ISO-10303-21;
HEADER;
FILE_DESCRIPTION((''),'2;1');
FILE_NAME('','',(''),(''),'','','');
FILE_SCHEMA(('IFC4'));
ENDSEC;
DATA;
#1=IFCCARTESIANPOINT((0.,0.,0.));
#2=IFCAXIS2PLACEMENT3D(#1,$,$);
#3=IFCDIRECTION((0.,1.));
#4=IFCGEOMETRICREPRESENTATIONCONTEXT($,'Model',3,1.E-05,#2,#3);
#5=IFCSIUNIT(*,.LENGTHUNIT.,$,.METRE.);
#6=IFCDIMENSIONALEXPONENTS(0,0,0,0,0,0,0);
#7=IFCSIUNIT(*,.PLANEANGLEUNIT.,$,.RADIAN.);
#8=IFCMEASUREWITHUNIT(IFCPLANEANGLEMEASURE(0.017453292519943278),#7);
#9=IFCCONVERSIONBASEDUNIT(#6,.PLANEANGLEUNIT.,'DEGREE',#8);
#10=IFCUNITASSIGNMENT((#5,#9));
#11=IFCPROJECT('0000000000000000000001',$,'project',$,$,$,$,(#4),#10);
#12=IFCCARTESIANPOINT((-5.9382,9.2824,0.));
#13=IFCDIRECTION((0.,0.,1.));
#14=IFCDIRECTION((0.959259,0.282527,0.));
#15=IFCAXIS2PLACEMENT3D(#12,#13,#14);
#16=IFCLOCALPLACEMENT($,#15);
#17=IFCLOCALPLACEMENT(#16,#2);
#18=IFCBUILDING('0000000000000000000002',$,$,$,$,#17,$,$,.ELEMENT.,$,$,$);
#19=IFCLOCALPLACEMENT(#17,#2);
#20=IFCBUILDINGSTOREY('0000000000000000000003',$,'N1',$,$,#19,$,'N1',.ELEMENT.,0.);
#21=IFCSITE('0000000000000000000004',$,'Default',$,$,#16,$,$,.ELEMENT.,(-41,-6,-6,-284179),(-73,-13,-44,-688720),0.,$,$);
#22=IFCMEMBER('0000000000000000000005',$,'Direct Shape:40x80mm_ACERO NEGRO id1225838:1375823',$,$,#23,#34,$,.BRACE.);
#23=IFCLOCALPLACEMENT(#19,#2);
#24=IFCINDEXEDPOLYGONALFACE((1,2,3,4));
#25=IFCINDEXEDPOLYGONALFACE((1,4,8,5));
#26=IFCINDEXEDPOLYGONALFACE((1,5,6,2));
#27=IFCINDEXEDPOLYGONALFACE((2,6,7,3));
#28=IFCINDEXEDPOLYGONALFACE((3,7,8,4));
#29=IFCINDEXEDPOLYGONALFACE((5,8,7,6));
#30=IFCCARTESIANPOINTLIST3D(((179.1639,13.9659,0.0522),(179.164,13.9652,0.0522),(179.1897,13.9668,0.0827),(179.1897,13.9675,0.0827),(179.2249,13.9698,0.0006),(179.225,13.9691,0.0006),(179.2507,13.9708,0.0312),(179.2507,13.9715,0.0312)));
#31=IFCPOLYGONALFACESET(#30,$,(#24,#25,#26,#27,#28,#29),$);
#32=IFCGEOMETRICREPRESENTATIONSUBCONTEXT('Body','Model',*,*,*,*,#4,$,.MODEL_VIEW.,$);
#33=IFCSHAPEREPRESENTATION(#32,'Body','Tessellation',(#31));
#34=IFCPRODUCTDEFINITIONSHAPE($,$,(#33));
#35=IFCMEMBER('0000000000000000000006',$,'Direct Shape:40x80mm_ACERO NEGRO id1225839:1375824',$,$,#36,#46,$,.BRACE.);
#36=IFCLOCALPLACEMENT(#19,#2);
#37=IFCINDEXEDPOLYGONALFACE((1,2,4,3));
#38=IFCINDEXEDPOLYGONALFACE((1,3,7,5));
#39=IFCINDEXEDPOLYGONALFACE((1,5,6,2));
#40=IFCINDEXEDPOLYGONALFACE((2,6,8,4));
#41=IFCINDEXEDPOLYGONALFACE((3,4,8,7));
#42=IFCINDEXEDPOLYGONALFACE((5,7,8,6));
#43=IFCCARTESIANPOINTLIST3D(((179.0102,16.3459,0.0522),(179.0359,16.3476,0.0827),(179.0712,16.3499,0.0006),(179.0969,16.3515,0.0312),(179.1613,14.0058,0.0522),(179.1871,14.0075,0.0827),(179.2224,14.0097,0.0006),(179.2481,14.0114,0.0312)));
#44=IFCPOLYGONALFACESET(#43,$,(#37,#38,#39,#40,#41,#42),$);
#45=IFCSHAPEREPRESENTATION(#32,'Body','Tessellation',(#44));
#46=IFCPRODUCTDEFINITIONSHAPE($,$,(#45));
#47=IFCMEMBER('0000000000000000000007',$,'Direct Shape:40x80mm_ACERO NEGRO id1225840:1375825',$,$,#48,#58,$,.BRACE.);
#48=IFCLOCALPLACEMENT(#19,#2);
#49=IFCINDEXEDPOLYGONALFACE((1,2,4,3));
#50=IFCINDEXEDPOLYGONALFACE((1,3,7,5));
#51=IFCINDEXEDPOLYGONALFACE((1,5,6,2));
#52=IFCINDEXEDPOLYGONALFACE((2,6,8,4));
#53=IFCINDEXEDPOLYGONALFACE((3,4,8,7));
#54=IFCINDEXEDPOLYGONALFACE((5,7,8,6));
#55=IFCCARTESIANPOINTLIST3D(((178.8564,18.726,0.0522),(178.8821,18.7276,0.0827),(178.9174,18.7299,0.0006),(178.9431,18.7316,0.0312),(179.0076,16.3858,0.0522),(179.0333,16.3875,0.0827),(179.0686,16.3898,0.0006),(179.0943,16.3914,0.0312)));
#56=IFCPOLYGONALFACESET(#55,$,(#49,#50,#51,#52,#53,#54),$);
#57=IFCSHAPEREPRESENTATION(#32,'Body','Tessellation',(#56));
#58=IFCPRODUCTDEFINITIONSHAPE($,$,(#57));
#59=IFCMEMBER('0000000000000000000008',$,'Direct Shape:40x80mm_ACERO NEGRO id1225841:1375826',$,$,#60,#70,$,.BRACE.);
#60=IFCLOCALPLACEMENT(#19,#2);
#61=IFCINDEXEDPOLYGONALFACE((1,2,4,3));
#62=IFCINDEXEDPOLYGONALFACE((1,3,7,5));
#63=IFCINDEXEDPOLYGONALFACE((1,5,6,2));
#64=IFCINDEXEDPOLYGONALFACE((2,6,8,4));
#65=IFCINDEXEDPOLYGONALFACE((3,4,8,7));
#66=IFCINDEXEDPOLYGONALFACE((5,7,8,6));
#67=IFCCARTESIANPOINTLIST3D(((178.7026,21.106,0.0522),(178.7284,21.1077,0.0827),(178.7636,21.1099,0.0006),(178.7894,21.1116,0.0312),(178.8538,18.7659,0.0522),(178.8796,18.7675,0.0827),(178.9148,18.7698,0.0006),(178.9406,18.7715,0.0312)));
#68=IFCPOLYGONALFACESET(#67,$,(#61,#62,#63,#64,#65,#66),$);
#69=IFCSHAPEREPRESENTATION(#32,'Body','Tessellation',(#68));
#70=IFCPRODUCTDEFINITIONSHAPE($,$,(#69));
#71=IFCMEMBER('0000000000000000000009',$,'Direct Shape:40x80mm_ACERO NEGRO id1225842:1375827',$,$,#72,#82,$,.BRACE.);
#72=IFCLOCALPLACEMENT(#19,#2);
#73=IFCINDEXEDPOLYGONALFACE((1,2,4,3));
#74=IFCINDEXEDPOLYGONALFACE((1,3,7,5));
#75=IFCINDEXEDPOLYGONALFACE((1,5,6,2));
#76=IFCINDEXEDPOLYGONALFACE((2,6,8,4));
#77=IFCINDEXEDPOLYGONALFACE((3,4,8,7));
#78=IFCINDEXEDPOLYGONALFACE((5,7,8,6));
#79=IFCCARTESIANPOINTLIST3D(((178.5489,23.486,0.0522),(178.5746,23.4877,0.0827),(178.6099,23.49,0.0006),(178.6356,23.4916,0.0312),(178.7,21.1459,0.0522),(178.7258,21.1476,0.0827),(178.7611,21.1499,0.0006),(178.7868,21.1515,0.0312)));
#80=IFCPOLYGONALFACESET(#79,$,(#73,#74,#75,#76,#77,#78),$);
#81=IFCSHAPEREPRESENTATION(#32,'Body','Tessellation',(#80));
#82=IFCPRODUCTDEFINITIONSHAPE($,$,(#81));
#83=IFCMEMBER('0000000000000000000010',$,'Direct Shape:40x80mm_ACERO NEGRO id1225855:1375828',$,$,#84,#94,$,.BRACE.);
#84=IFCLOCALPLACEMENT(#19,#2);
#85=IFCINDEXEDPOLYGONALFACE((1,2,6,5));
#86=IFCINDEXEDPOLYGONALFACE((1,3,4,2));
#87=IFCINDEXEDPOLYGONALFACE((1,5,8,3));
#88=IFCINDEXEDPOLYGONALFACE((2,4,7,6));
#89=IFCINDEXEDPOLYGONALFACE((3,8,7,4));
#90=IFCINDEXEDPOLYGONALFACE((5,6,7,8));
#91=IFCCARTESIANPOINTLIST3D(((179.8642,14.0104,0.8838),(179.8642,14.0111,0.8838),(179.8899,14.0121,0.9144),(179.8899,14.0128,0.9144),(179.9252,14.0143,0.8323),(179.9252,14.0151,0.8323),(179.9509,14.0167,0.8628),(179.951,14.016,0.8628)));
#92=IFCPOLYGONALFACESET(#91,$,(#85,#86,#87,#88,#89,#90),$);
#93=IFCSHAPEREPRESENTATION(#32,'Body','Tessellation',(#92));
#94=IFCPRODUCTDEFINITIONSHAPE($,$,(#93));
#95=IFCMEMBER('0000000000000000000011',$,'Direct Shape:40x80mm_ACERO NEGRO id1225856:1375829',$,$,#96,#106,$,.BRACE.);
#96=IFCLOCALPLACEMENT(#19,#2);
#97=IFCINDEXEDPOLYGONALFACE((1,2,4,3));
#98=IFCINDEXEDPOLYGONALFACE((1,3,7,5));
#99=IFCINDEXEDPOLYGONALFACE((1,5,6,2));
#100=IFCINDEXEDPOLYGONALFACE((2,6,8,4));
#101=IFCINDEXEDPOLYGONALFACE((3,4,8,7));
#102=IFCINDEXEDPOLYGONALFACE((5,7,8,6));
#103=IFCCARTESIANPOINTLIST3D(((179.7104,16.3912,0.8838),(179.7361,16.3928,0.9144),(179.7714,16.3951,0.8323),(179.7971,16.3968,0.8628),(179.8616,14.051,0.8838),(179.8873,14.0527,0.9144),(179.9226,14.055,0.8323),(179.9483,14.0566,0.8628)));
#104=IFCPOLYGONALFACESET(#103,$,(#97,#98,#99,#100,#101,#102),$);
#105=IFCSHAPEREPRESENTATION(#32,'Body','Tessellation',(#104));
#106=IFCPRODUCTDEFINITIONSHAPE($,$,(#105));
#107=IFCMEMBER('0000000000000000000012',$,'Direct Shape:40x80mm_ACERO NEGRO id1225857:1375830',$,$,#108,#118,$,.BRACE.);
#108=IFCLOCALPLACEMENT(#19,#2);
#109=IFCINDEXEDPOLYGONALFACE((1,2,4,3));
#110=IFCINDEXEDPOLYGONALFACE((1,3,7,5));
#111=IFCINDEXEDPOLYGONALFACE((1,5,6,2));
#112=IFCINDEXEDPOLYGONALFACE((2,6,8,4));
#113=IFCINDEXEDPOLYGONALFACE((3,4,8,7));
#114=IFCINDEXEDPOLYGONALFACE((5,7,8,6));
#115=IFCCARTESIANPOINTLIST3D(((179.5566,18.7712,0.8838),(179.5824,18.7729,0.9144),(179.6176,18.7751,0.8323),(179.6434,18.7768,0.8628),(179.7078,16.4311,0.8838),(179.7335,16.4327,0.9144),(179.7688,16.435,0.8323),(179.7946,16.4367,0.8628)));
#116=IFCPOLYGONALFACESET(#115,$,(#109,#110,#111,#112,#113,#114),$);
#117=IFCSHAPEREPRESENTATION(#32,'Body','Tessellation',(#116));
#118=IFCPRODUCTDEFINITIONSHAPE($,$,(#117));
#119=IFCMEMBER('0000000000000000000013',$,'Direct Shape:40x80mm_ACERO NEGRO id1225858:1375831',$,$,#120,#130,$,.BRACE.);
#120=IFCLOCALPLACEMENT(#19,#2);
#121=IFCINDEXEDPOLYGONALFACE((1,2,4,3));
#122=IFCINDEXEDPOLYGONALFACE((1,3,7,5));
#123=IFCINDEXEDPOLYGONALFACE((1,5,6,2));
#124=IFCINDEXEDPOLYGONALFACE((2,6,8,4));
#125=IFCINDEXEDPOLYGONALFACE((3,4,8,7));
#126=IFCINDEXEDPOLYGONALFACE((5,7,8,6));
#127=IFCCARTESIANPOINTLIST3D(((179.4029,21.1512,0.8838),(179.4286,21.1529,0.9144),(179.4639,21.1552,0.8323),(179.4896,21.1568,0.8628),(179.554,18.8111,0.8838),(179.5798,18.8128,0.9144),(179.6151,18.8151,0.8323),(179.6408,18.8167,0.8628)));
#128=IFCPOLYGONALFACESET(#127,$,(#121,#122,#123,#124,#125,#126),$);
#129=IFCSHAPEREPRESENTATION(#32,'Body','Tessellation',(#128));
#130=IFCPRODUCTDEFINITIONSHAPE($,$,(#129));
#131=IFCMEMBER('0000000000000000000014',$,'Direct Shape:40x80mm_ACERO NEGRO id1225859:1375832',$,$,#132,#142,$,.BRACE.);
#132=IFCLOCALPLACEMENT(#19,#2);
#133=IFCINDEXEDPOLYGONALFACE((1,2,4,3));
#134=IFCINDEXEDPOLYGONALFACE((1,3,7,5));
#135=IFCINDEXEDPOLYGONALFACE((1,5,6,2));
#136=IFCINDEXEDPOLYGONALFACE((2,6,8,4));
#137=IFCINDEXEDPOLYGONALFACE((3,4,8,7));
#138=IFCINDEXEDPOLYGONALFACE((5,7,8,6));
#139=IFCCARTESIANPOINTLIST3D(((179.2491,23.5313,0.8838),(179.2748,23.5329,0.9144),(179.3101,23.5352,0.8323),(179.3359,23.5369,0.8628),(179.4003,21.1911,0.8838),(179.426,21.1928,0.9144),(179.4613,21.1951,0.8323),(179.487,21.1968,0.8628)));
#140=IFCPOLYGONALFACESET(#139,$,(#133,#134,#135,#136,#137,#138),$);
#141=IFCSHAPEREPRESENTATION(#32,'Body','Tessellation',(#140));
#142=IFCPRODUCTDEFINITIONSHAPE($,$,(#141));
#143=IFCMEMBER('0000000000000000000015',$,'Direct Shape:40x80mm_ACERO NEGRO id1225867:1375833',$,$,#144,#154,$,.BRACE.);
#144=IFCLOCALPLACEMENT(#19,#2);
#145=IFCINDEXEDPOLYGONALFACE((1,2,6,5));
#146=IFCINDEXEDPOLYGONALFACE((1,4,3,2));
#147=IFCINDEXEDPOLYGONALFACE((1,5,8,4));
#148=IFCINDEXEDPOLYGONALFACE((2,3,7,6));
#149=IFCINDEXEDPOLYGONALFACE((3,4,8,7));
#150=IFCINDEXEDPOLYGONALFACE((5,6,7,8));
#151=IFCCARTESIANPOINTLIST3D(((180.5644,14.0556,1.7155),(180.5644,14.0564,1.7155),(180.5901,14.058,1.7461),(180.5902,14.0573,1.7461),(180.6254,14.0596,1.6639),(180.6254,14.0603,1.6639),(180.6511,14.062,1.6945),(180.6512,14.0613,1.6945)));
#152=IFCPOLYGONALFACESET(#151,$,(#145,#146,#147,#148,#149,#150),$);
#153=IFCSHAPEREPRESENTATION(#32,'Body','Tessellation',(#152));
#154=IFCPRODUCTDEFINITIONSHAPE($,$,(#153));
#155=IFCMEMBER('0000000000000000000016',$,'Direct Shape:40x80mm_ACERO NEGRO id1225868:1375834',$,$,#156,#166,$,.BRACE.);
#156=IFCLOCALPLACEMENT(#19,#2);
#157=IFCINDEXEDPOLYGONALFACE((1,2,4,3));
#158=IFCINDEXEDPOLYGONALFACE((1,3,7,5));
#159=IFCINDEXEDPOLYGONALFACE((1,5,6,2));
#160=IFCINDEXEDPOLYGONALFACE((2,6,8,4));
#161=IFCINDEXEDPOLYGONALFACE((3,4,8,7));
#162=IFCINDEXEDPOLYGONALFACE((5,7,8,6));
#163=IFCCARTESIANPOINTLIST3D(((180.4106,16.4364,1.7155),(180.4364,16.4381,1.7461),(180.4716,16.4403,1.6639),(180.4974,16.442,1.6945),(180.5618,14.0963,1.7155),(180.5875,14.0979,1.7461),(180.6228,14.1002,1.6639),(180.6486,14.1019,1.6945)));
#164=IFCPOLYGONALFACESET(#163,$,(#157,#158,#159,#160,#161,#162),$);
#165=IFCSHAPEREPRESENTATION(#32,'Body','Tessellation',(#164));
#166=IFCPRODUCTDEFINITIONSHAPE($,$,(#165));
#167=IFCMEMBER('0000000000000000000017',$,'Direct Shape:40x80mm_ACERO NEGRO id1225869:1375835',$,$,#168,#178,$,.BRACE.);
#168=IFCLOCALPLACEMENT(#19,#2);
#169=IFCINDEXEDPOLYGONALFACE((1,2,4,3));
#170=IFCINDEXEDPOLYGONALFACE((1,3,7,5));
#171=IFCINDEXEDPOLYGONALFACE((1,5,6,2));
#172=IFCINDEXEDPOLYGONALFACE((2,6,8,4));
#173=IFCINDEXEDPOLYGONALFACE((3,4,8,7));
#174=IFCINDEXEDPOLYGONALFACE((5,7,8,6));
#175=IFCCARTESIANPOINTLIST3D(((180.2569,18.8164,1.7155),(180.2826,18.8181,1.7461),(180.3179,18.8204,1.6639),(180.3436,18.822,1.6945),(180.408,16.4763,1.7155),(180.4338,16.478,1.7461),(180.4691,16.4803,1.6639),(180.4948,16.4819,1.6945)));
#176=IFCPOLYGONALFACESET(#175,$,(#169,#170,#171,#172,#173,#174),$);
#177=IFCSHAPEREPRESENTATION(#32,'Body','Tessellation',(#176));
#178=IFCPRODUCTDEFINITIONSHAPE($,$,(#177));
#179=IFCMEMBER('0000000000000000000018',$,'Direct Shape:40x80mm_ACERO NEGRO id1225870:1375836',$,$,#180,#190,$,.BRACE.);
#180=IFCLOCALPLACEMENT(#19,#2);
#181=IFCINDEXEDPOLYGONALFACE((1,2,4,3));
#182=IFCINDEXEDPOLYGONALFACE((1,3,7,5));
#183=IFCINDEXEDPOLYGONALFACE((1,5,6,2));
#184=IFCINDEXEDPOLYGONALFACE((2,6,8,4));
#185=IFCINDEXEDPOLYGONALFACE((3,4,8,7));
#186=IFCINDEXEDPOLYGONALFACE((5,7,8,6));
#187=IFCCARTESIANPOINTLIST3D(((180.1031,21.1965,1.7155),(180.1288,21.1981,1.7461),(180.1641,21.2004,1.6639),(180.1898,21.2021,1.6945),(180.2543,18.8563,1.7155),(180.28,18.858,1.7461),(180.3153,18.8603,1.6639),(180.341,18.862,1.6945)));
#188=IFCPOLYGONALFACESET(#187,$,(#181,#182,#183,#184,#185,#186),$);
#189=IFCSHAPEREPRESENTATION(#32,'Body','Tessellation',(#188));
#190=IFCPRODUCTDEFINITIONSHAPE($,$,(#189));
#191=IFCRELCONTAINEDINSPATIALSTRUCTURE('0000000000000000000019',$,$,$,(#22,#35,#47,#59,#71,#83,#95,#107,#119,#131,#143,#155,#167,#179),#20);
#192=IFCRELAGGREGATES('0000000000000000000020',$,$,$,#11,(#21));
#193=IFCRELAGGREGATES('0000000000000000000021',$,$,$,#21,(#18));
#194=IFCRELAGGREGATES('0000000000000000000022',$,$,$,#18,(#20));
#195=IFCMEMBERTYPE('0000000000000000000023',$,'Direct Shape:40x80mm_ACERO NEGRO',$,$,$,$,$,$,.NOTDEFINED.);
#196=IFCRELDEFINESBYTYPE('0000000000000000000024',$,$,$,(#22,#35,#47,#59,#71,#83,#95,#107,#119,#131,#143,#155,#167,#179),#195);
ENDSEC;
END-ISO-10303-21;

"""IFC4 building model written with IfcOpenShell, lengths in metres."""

from ifc_helpers import new_model, entity, si_unit, converted_unit, direction, frame, frame_2d, origin, place, context, subcontext, project, spatial, rectangle, extrude, type_object, element, save


model = new_model("IFC4")

# Units and contexts
model_context = context("Model", 3, precision=1e-05, world=origin(), true_north=direction((0.0, 1.0)))
body_context = subcontext(model_context, "Body", "Model", "MODEL_VIEW")
ifc_project = project(units=[si_unit("LENGTHUNIT", "METRE"), converted_unit("PLANEANGLEUNIT", "DEGREE", entity("IfcPlaneAngleMeasure", 0.017453292519943278), si_unit("PLANEANGLEUNIT", "RADIAN"), dimensions=[0, 0, 0, 0, 0, 0, 0])], contexts=[model_context])

# Site, building, storey
site_placement = place(None, frame((-5.9382, 9.2824, 0.0), z_axis=(0.0, 0.0, 1.0), x_axis=(0.959259, 0.282527, 0.0)))
site = spatial("IfcSite", under=ifc_project, at=site_placement, Name="Default", CompositionType="ELEMENT", RefLatitude=(-41, -6, -6, -284179), RefLongitude=(-73, -13, -44, -688720), RefElevation=0.0)
building_placement = place(site_placement, origin())
building = spatial("IfcBuilding", under=site, at=building_placement, CompositionType="ELEMENT")
storey_placement = place(building_placement, origin())
storey = spatial("IfcBuildingStorey", under=building, at=storey_placement, Name="N1", LongName="N1", CompositionType="ELEMENT", Elevation=0.0)

# Members
member_type = type_object("IfcMemberType", Name="Direct Shape:40x80mm_ACERO NEGRO", PredefinedType="NOTDEFINED")
member_1_placement = place(storey_placement, origin())
element("IfcMember", 1, at=member_1_placement, inside=storey, type_object=member_type, Name="Direct Shape:40x80mm_ACERO NEGRO id1225838:1375823", PredefinedType="BRACE", context=body_context, shape_type="SweptSolid", body=[
    extrude(rectangle(XDim=0.04, YDim=0.0007, at=frame_2d((0.0, 0.0), x_axis=(0.0, 1.0))), frame((179.1768, 13.9664, 0.0675), z_axis=(0.762714, 0.049276, -0.644857), x_axis=(-0.064471, 0.99792, 0.0)), (0.0, 0.0, 1.0), 0.08),
])
member_2_placement = place(storey_placement, origin())
element("IfcMember", 2, at=member_2_placement, inside=storey, type_object=member_type, Name="Direct Shape:40x80mm_ACERO NEGRO id1225839:1375824", PredefinedType="BRACE", context=body_context, shape_type="SweptSolid", body=[
    extrude(rectangle(XDim=0.04, YDim=0.08, at=frame_2d((0.0, 0.0), x_axis=(0.0, 1.0))), frame((179.2047, 14.0086, 0.0417), z_axis=(-0.064471, 0.99792, 0.0), x_axis=(0.762714, 0.049276, -0.644857)), (0.0, 0.0, 1.0), 2.345),
])
member_3_placement = place(storey_placement, origin())
element("IfcMember", 3, at=member_3_placement, inside=storey, type_object=member_type, Name="Direct Shape:40x80mm_ACERO NEGRO id1225840:1375825", PredefinedType="BRACE", context=body_context, shape_type="SweptSolid", body=[
    extrude(rectangle(XDim=0.04, YDim=0.08, at=frame_2d((0.0, 0.0), x_axis=(0.0, 1.0))), frame((179.051, 16.3886, 0.0417), z_axis=(-0.064471, 0.99792, 0.0), x_axis=(0.762714, 0.049276, -0.644857)), (0.0, 0.0, 1.0), 2.345),
])
member_4_placement = place(storey_placement, origin())
element("IfcMember", 4, at=member_4_placement, inside=storey, type_object=member_type, Name="Direct Shape:40x80mm_ACERO NEGRO id1225841:1375826", PredefinedType="BRACE", context=body_context, shape_type="SweptSolid", body=[
    extrude(rectangle(XDim=0.04, YDim=0.08, at=frame_2d((0.0, 0.0), x_axis=(0.0, 1.0))), frame((178.8972, 18.7687, 0.0417), z_axis=(-0.064471, 0.99792, 0.0), x_axis=(0.762714, 0.049276, -0.644857)), (0.0, 0.0, 1.0), 2.345),
])
member_5_placement = place(storey_placement, origin())
element("IfcMember", 5, at=member_5_placement, inside=storey, type_object=member_type, Name="Direct Shape:40x80mm_ACERO NEGRO id1225842:1375827", PredefinedType="BRACE", context=body_context, shape_type="SweptSolid", body=[
    extrude(rectangle(XDim=0.04, YDim=0.08, at=frame_2d((0.0, 0.0), x_axis=(0.0, 1.0))), frame((178.7434, 21.1487, 0.0417), z_axis=(-0.064471, 0.99792, 0.0), x_axis=(0.762714, 0.049276, -0.644857)), (0.0, 0.0, 1.0), 2.345),
])
member_6_placement = place(storey_placement, origin())
element("IfcMember", 6, at=member_6_placement, inside=storey, type_object=member_type, Name="Direct Shape:40x80mm_ACERO NEGRO id1225855:1375828", PredefinedType="BRACE", context=body_context, shape_type="SweptSolid", body=[
    extrude(rectangle(XDim=0.04, YDim=0.0007, at=frame_2d((0.0, 0.0), x_axis=(0.0, 1.0))), frame((179.877, 14.0116, 0.8991), z_axis=(0.762714, 0.049276, -0.644857), x_axis=(-0.064471, 0.99792, 0.0)), (0.0, 0.0, 1.0), 0.08),
])
member_7_placement = place(storey_placement, origin())
element("IfcMember", 7, at=member_7_placement, inside=storey, type_object=member_type, Name="Direct Shape:40x80mm_ACERO NEGRO id1225856:1375829", PredefinedType="BRACE", context=body_context, shape_type="SweptSolid", body=[
    extrude(rectangle(XDim=0.04, YDim=0.08, at=frame_2d((0.0, 0.0), x_axis=(0.0, 1.0))), frame((179.905, 14.0538, 0.8733), z_axis=(-0.064471, 0.99792, 0.0), x_axis=(0.762714, 0.049276, -0.644857)), (0.0, 0.0, 1.0), 2.345),
])
member_8_placement = place(storey_placement, origin())
element("IfcMember", 8, at=member_8_placement, inside=storey, type_object=member_type, Name="Direct Shape:40x80mm_ACERO NEGRO id1225857:1375830", PredefinedType="BRACE", context=body_context, shape_type="SweptSolid", body=[
    extrude(rectangle(XDim=0.04, YDim=0.08, at=frame_2d((0.0, 0.0), x_axis=(0.0, 1.0))), frame((179.7512, 16.4339, 0.8733), z_axis=(-0.064471, 0.99792, 0.0), x_axis=(0.762714, 0.049276, -0.644857)), (0.0, 0.0, 1.0), 2.345),
])
member_9_placement = place(storey_placement, origin())
element("IfcMember", 9, at=member_9_placement, inside=storey, type_object=member_type, Name="Direct Shape:40x80mm_ACERO NEGRO id1225858:1375831", PredefinedType="BRACE", context=body_context, shape_type="SweptSolid", body=[
    extrude(rectangle(XDim=0.04, YDim=0.08, at=frame_2d((0.0, 0.0), x_axis=(0.0, 1.0))), frame((179.5974, 18.8139, 0.8733), z_axis=(-0.064471, 0.99792, 0.0), x_axis=(0.762714, 0.049276, -0.644857)), (0.0, 0.0, 1.0), 2.345),
])
member_10_placement = place(storey_placement, origin())
element("IfcMember", 10, at=member_10_placement, inside=storey, type_object=member_type, Name="Direct Shape:40x80mm_ACERO NEGRO id1225859:1375832", PredefinedType="BRACE", context=body_context, shape_type="SweptSolid", body=[
    extrude(rectangle(XDim=0.04, YDim=0.08, at=frame_2d((0.0, 0.0), x_axis=(0.0, 1.0))), frame((179.4437, 21.194, 0.8733), z_axis=(-0.064471, 0.99792, 0.0), x_axis=(0.762714, 0.049276, -0.644857)), (0.0, 0.0, 1.0), 2.345),
])
member_11_placement = place(storey_placement, origin())
element("IfcMember", 11, at=member_11_placement, inside=storey, type_object=member_type, Name="Direct Shape:40x80mm_ACERO NEGRO id1225867:1375833", PredefinedType="BRACE", context=body_context, shape_type="SweptSolid", body=[
    extrude(rectangle(XDim=0.04, YDim=0.0007, at=frame_2d((0.0, 0.0), x_axis=(0.0, 1.0))), frame((180.5773, 14.0568, 1.7308), z_axis=(0.762714, 0.049276, -0.644857), x_axis=(-0.064471, 0.99792, 0.0)), (0.0, 0.0, 1.0), 0.08),
])
member_12_placement = place(storey_placement, origin())
element("IfcMember", 12, at=member_12_placement, inside=storey, type_object=member_type, Name="Direct Shape:40x80mm_ACERO NEGRO id1225868:1375834", PredefinedType="BRACE", context=body_context, shape_type="SweptSolid", body=[
    extrude(rectangle(XDim=0.04, YDim=0.08, at=frame_2d((0.0, 0.0), x_axis=(0.0, 1.0))), frame((180.6052, 14.0991, 1.705), z_axis=(-0.064471, 0.99792, 0.0), x_axis=(0.762714, 0.049276, -0.644857)), (0.0, 0.0, 1.0), 2.345),
])
member_13_placement = place(storey_placement, origin())
element("IfcMember", 13, at=member_13_placement, inside=storey, type_object=member_type, Name="Direct Shape:40x80mm_ACERO NEGRO id1225869:1375835", PredefinedType="BRACE", context=body_context, shape_type="SweptSolid", body=[
    extrude(rectangle(XDim=0.04, YDim=0.08, at=frame_2d((0.0, 0.0), x_axis=(0.0, 1.0))), frame((180.4514, 16.4791, 1.705), z_axis=(-0.064471, 0.99792, 0.0), x_axis=(0.762714, 0.049276, -0.644857)), (0.0, 0.0, 1.0), 2.345),
])
member_14_placement = place(storey_placement, origin())
element("IfcMember", 14, at=member_14_placement, inside=storey, type_object=member_type, Name="Direct Shape:40x80mm_ACERO NEGRO id1225870:1375836", PredefinedType="BRACE", context=body_context, shape_type="SweptSolid", body=[
    extrude(rectangle(XDim=0.04, YDim=0.08, at=frame_2d((0.0, 0.0), x_axis=(0.0, 1.0))), frame((180.2977, 18.8592, 1.705), z_axis=(-0.064471, 0.99792, 0.0), x_axis=(0.762714, 0.049276, -0.644857)), (0.0, 0.0, 1.0), 2.345),
])

save(model, "model.ifc")
